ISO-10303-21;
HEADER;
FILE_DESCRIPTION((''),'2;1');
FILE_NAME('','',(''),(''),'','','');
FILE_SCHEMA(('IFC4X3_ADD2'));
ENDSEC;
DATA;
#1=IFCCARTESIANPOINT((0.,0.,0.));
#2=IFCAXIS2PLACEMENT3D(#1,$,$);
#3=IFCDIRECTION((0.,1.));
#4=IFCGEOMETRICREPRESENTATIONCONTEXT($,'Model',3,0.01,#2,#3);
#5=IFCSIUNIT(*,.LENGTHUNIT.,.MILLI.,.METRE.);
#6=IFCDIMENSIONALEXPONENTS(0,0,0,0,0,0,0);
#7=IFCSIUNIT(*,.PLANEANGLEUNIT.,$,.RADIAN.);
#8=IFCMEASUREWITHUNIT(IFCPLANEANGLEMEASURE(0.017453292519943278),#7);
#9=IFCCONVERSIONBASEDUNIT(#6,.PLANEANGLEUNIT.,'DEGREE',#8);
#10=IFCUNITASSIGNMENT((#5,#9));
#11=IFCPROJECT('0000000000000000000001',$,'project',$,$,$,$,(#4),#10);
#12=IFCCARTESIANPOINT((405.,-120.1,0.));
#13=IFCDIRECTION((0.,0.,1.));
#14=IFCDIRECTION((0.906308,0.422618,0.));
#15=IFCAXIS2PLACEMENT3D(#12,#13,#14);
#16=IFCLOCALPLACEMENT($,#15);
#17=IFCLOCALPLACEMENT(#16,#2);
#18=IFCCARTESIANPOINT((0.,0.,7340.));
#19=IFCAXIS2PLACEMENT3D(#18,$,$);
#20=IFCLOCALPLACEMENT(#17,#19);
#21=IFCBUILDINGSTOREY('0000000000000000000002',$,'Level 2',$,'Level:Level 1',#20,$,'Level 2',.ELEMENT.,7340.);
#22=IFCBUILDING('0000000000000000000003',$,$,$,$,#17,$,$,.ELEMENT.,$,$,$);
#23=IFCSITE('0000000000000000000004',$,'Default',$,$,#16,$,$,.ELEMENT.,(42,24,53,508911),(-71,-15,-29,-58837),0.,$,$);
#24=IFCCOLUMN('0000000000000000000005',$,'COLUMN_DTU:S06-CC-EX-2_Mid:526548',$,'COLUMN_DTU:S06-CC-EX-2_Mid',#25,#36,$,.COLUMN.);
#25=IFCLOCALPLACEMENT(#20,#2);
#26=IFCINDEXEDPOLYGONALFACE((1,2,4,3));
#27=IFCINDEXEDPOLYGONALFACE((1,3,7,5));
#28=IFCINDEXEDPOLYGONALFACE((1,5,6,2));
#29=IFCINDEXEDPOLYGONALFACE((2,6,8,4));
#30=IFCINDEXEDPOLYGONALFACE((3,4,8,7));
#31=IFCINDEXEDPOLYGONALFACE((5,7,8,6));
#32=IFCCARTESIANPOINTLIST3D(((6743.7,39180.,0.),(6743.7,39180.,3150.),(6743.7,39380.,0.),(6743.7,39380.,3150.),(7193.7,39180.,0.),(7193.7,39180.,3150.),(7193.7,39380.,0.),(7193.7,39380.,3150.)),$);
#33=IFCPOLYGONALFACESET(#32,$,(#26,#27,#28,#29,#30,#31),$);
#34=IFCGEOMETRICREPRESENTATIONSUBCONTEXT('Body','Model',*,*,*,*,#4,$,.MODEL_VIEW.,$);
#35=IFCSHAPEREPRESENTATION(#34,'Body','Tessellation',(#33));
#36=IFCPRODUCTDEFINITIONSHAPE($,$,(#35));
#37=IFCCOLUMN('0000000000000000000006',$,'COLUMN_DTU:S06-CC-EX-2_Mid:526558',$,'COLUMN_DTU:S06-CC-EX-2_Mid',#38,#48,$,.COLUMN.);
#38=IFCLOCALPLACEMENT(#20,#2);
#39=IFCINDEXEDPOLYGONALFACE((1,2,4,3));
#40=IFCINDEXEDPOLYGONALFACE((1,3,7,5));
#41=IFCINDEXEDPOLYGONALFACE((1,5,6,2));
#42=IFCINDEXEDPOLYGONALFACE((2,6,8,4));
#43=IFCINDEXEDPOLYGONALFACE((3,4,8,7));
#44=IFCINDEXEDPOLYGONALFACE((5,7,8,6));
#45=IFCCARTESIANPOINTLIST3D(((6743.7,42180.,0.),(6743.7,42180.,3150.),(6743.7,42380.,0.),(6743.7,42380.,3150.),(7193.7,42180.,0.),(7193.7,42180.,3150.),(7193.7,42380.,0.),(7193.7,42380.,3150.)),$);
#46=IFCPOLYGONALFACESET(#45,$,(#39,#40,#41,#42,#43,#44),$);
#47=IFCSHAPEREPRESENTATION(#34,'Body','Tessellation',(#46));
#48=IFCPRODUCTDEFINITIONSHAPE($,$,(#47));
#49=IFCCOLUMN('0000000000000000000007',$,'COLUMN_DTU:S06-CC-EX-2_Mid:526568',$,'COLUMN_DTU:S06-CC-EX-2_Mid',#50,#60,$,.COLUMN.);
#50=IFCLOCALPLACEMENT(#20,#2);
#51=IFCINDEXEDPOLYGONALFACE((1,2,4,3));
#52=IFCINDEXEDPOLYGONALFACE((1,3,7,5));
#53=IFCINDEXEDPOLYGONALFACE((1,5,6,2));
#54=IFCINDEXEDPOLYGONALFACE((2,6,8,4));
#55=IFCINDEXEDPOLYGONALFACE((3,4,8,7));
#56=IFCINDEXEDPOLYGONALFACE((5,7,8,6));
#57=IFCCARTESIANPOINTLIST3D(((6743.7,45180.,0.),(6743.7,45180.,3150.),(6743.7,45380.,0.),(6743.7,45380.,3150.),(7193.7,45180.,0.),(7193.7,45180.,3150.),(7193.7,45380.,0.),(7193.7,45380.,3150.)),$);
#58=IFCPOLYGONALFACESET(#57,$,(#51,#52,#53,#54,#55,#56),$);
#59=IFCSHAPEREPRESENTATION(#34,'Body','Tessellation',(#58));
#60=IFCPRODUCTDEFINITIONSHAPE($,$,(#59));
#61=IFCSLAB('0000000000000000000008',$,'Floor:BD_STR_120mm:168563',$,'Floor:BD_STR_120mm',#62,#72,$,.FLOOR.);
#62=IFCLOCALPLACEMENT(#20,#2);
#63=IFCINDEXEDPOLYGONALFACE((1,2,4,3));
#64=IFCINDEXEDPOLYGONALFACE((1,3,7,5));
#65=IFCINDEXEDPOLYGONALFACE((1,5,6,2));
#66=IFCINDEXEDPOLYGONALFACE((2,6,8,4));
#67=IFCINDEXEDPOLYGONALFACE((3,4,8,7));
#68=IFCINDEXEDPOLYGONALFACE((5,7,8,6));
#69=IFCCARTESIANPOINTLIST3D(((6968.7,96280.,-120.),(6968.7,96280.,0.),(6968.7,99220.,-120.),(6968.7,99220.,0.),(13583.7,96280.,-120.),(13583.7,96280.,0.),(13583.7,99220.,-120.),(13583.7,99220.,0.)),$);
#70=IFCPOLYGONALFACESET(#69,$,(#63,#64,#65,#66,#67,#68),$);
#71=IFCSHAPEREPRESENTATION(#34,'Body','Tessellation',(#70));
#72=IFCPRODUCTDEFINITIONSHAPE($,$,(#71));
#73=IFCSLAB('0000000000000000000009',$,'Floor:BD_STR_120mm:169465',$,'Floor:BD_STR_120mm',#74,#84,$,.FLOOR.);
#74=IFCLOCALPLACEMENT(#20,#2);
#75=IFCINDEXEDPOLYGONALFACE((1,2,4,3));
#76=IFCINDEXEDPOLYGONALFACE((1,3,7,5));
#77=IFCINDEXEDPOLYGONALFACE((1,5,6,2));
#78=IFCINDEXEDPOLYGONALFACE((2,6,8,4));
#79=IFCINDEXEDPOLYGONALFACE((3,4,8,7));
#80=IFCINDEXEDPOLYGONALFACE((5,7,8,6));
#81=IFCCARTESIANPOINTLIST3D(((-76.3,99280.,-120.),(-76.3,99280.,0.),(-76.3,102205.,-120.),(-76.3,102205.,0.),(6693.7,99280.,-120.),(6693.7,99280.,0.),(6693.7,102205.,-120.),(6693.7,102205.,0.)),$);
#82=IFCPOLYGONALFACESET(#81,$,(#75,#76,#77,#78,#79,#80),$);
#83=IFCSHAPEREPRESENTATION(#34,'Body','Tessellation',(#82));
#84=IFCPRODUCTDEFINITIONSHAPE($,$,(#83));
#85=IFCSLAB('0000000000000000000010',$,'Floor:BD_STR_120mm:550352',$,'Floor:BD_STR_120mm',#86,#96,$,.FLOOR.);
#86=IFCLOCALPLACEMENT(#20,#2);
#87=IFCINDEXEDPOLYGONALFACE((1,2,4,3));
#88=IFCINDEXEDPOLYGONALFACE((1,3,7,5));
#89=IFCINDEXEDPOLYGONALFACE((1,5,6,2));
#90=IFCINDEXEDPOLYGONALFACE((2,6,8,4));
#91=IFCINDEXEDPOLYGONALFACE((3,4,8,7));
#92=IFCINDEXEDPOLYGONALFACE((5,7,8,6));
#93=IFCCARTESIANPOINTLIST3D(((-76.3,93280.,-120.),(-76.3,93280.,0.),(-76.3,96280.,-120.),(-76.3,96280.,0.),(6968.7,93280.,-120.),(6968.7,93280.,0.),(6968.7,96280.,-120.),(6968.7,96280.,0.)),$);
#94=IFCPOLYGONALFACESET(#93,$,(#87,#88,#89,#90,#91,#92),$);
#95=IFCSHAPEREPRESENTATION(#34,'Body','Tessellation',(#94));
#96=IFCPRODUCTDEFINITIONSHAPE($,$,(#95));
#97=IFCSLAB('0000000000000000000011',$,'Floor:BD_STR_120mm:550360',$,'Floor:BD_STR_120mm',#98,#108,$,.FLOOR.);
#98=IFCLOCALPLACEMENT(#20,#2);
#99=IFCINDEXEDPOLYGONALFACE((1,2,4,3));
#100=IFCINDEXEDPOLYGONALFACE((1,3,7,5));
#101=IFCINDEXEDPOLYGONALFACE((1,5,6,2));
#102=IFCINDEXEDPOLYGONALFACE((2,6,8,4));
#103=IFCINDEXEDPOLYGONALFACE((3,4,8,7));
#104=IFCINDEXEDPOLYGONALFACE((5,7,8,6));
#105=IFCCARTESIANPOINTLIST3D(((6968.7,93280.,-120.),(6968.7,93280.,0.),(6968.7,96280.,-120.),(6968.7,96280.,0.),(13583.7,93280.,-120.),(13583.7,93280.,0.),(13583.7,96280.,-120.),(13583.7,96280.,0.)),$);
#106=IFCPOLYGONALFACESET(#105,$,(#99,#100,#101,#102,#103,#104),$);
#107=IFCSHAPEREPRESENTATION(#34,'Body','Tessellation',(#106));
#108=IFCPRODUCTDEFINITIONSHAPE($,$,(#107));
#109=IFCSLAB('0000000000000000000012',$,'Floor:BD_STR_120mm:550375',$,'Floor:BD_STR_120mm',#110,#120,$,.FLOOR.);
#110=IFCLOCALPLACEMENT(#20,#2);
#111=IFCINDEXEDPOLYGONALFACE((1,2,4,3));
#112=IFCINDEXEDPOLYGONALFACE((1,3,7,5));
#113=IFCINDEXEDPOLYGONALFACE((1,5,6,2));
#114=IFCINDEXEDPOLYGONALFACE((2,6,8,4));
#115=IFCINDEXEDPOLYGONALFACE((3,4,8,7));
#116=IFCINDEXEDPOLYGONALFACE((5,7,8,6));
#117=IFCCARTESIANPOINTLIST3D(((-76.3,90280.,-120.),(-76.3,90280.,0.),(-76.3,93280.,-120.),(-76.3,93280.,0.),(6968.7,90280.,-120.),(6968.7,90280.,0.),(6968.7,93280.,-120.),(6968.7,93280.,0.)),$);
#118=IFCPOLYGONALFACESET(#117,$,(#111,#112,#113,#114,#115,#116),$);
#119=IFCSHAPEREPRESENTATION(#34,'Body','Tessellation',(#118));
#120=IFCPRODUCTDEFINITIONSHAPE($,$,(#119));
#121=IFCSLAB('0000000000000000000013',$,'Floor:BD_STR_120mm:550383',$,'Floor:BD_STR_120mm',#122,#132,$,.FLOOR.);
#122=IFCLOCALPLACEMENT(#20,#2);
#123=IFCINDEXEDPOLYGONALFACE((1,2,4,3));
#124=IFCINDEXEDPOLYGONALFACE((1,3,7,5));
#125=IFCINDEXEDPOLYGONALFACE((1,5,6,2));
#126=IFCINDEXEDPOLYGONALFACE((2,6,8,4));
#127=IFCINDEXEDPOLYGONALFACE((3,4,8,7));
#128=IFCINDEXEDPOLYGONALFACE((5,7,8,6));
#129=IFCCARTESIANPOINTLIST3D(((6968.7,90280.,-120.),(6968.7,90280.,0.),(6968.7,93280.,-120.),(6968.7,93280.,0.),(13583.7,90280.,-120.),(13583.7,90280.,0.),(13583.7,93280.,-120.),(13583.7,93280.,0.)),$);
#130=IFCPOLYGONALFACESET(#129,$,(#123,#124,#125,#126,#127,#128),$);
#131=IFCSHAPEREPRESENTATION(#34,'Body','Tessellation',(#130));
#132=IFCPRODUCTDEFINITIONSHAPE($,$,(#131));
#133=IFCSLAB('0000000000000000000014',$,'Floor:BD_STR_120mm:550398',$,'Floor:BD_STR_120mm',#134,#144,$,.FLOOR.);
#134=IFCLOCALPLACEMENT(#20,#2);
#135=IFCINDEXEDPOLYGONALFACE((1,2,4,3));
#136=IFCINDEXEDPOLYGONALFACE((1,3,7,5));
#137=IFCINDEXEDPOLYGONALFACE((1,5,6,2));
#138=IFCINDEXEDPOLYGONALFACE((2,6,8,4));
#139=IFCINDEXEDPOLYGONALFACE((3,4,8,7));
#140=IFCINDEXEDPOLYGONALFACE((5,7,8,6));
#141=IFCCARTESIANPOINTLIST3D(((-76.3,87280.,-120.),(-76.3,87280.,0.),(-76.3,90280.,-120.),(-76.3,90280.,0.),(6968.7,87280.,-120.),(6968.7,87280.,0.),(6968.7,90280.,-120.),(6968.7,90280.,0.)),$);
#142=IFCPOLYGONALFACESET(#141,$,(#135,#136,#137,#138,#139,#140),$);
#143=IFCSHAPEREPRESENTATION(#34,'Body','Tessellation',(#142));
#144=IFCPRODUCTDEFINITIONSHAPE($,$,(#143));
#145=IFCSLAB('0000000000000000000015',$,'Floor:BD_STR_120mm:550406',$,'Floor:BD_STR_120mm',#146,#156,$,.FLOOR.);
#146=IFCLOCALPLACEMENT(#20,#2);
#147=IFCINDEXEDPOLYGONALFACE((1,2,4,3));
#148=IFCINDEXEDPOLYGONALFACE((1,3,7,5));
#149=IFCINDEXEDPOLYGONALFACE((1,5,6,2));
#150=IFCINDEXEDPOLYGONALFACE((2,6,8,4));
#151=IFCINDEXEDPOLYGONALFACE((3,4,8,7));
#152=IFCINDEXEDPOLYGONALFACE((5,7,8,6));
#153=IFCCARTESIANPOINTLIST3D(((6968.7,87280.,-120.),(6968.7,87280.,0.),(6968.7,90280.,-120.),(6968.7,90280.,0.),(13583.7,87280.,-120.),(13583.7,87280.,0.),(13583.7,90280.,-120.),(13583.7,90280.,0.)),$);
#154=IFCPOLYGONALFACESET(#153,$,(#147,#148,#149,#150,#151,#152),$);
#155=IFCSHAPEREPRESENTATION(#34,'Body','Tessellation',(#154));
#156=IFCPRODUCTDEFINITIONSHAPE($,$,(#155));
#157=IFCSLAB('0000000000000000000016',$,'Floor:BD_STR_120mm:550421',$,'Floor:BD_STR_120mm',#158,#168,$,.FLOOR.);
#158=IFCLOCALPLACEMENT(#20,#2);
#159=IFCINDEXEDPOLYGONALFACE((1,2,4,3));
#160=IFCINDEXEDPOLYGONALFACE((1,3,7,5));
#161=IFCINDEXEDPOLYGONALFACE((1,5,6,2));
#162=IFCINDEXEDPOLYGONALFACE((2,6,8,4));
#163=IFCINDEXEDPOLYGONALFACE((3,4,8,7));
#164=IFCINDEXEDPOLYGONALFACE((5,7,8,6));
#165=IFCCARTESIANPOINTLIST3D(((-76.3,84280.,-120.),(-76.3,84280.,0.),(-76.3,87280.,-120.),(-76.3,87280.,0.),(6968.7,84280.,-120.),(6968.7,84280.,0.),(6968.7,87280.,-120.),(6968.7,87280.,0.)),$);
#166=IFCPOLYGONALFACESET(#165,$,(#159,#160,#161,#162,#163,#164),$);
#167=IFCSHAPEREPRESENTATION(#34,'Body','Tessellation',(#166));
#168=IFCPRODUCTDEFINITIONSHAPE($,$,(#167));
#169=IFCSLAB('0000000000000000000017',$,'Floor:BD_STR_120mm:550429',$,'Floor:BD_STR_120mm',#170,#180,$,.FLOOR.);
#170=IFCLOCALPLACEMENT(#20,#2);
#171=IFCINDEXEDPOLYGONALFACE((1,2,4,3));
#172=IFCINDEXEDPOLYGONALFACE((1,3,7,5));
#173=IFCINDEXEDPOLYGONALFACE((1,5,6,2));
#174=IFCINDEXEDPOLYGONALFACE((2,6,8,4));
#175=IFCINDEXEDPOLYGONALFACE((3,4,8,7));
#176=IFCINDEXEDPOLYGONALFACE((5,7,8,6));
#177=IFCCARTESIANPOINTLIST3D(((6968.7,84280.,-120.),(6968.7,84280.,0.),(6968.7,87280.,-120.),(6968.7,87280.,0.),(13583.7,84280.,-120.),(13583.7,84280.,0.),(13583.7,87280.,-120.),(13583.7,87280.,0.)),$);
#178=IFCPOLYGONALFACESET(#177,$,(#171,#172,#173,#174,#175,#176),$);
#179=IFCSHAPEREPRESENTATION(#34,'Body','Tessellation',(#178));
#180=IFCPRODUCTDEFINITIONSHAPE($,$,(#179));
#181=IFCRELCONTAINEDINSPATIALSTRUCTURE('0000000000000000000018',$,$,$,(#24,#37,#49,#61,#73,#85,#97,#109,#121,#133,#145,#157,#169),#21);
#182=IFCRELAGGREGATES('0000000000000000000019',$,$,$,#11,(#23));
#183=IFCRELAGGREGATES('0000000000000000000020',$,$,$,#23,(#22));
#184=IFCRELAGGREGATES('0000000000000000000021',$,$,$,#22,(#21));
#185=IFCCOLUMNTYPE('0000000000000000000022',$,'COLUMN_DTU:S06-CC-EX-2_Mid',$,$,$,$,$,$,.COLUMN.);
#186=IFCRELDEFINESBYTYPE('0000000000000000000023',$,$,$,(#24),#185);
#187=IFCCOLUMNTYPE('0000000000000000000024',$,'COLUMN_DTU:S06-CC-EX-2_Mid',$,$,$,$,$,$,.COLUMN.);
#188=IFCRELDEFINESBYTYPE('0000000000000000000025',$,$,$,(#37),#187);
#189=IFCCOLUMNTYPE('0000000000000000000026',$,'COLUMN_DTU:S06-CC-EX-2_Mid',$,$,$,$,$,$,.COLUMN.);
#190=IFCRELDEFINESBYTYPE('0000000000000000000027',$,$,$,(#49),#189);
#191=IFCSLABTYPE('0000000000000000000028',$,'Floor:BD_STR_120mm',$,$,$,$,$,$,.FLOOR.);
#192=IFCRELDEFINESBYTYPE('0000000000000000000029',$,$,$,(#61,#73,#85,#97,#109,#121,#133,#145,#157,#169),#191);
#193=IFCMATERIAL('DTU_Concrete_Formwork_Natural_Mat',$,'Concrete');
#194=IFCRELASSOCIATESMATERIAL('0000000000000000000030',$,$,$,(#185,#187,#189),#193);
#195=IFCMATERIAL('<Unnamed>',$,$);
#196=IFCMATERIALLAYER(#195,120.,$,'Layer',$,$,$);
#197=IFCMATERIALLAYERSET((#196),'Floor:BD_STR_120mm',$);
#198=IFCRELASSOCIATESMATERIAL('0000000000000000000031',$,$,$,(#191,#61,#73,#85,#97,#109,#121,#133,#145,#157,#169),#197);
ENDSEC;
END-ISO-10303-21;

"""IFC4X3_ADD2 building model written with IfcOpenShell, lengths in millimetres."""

from ifc_helpers import new_model, entity, si_unit, converted_unit, direction, frame, frame_2d, origin, origin_2d_with_axis, place, context, subcontext, project, spatial, rectangle, extrude, source, transform, mapped, material, layer, layer_set, layer_usage, material_profile, profile_set, type_object, type_shapes, element, save


model = new_model("IFC4X3_ADD2")

# Units and contexts
model_context = context("Model", 3, precision=0.01, world=origin(), true_north=direction((0.0, 1.0)))
body_context = subcontext(model_context, "Body", "Model", "MODEL_VIEW")
ifc_project = project(units=[si_unit("LENGTHUNIT", "METRE", prefix="MILLI"), converted_unit("PLANEANGLEUNIT", "DEGREE", entity("IfcPlaneAngleMeasure", 0.017453292519943278), si_unit("PLANEANGLEUNIT", "RADIAN"), dimensions=[0, 0, 0, 0, 0, 0, 0])], contexts=[model_context])

# Site, building, storey
site_placement = place(None, frame((405.0, -120.1, 0.0), z_axis=(0.0, 0.0, 1.0), x_axis=(0.906308, 0.422618, 0.0)))
site = spatial("IfcSite", under=ifc_project, at=site_placement, Name="Default", CompositionType="ELEMENT", RefLatitude=(42, 24, 53, 508911), RefLongitude=(-71, -15, -29, -58837), RefElevation=0.0)
building_placement = place(site_placement, origin())
building = spatial("IfcBuilding", under=site, at=building_placement, CompositionType="ELEMENT")
storey_placement = place(building_placement, frame((0.0, 0.0, 7340.0)))
storey = spatial("IfcBuildingStorey", under=building, at=storey_placement, Name="Level 2", ObjectType="Level:Level 1", LongName="Level 2", CompositionType="ELEMENT", Elevation=7340.0)

# Columns
ifc_material_1 = material(Name="DTU_Concrete_Formwork_Natural_Mat", Category="Concrete")
ifc_material_profile_1 = material_profile(ifc_material_1, rectangle(XDim=200.0, YDim=450.0, at=origin_2d_with_axis()), Name="S06-CC-EX-2_Mid")
ifc_profile_set_1 = profile_set([ifc_material_profile_1], Name="S06-CC-EX-2_Mid")
column_type_1 = type_object("IfcColumnType", Name="COLUMN_DTU:S06-CC-EX-2_Mid", PredefinedType="COLUMN", material=ifc_profile_set_1)
shared_shape_1 = source(origin(), body_context, "Body", "SweptSolid", [
    extrude(rectangle(XDim=200.0, YDim=450.0, at=frame_2d((0.0, 0.0), x_axis=(1.0, 0.0))), frame((6968.7, 39280.0, 7340.0), z_axis=(0.0, 0.0, 1.0), x_axis=(0.0, 1.0, 0.0)), (0.0, 0.0, 1.0), 3150.0),
])
type_shapes(column_type_1, [shared_shape_1])
column_1_placement = place(storey_placement, frame((0.0, 0.0, -7340.0)))
element("IfcColumn", 1, at=column_1_placement, inside=storey, type_object=column_type_1, Name="COLUMN_DTU:S06-CC-EX-2_Mid:526548", ObjectType="COLUMN_DTU:S06-CC-EX-2_Mid", PredefinedType="COLUMN", context=body_context, shape_type="MappedRepresentation", body=[
    mapped(shared_shape_1, transform((0.0, 0.0, 0.0), scale=1.0)),
])
column_type_2 = type_object("IfcColumnType", Name="COLUMN_DTU:S06-CC-EX-2_Mid", PredefinedType="COLUMN", material=ifc_profile_set_1)
shared_shape_2 = source(origin(), body_context, "Body", "SweptSolid", [
    extrude(rectangle(XDim=200.0, YDim=450.0, at=frame_2d((0.0, 0.0), x_axis=(1.0, 0.0))), frame((6968.7, 42280.0, 7340.0), z_axis=(0.0, 0.0, 1.0), x_axis=(0.0, 1.0, 0.0)), (0.0, 0.0, 1.0), 3150.0),
])
type_shapes(column_type_2, [shared_shape_2])
column_2_placement = place(storey_placement, frame((0.0, 0.0, -7340.0)))
element("IfcColumn", 2, at=column_2_placement, inside=storey, type_object=column_type_2, Name="COLUMN_DTU:S06-CC-EX-2_Mid:526558", ObjectType="COLUMN_DTU:S06-CC-EX-2_Mid", PredefinedType="COLUMN", context=body_context, shape_type="MappedRepresentation", body=[
    mapped(shared_shape_2, transform((0.0, 0.0, 0.0), scale=1.0)),
])
column_type_3 = type_object("IfcColumnType", Name="COLUMN_DTU:S06-CC-EX-2_Mid", PredefinedType="COLUMN", material=ifc_profile_set_1)
shared_shape_3 = source(origin(), body_context, "Body", "SweptSolid", [
    extrude(rectangle(XDim=200.0, YDim=450.0, at=frame_2d((0.0, 0.0), x_axis=(1.0, 0.0))), frame((6968.7, 45280.0, 7340.0), z_axis=(0.0, 0.0, 1.0), x_axis=(0.0, 1.0, 0.0)), (0.0, 0.0, 1.0), 3150.0),
])
type_shapes(column_type_3, [shared_shape_3])
column_3_placement = place(storey_placement, frame((0.0, 0.0, -7340.0)))
element("IfcColumn", 3, at=column_3_placement, inside=storey, type_object=column_type_3, Name="COLUMN_DTU:S06-CC-EX-2_Mid:526568", ObjectType="COLUMN_DTU:S06-CC-EX-2_Mid", PredefinedType="COLUMN", context=body_context, shape_type="MappedRepresentation", body=[
    mapped(shared_shape_3, transform((0.0, 0.0, 0.0), scale=1.0)),
])

# Slabs
ifc_material_2 = material(Name="<Unnamed>")
ifc_layer_1 = layer(ifc_material_2, 120.0, Name="Layer")
ifc_layer_set_1 = layer_set([ifc_layer_1], Name="Floor:BD_STR_120mm")
slab_type_1 = type_object("IfcSlabType", Name="Floor:BD_STR_120mm", PredefinedType="FLOOR", material=ifc_layer_set_1)
ifc_layer_usage_1 = layer_usage(ifc_layer_set_1, "AXIS3", "POSITIVE", 0.0)
slab_1_placement = place(storey_placement, origin())
element("IfcSlab", 4, at=slab_1_placement, inside=storey, type_object=slab_type_1, material=ifc_layer_usage_1, Name="Floor:BD_STR_120mm:168563", ObjectType="Floor:BD_STR_120mm", PredefinedType="FLOOR", context=body_context, shape_type="SweptSolid", body=[
    extrude(rectangle(XDim=2940.0, YDim=6615.0, at=frame_2d((0.0, 0.0), x_axis=(1.0, 0.0))), frame((10276.2, 97750.0, 0.0), z_axis=(0.0, 0.0, -1.0), x_axis=(0.0, 1.0, 0.0)), (0.0, 0.0, 1.0), 120.0),
])
ifc_layer_usage_2 = layer_usage(ifc_layer_set_1, "AXIS3", "POSITIVE", 0.0)
slab_2_placement = place(storey_placement, origin())
element("IfcSlab", 5, at=slab_2_placement, inside=storey, type_object=slab_type_1, material=ifc_layer_usage_2, Name="Floor:BD_STR_120mm:169465", ObjectType="Floor:BD_STR_120mm", PredefinedType="FLOOR", context=body_context, shape_type="SweptSolid", body=[
    extrude(rectangle(XDim=2925.0, YDim=6770.0, at=origin_2d_with_axis()), frame((3308.7, 100742.5, 0.0), z_axis=(0.0, 0.0, -1.0), x_axis=(0.0, 1.0, 0.0)), (0.0, 0.0, 1.0), 120.0),
])
ifc_layer_usage_3 = layer_usage(ifc_layer_set_1, "AXIS3", "POSITIVE", 0.0)
slab_3_placement = place(storey_placement, origin())
element("IfcSlab", 6, at=slab_3_placement, inside=storey, type_object=slab_type_1, material=ifc_layer_usage_3, Name="Floor:BD_STR_120mm:550352", ObjectType="Floor:BD_STR_120mm", PredefinedType="FLOOR", context=body_context, shape_type="SweptSolid", body=[
    extrude(rectangle(XDim=3000.0, YDim=7045.0, at=origin_2d_with_axis()), frame((3446.2, 94780.0, 0.0), z_axis=(0.0, 0.0, -1.0), x_axis=(0.0, 1.0, 0.0)), (0.0, 0.0, 1.0), 120.0),
])
ifc_layer_usage_4 = layer_usage(ifc_layer_set_1, "AXIS3", "POSITIVE", 0.0)
slab_4_placement = place(storey_placement, origin())
element("IfcSlab", 7, at=slab_4_placement, inside=storey, type_object=slab_type_1, material=ifc_layer_usage_4, Name="Floor:BD_STR_120mm:550360", ObjectType="Floor:BD_STR_120mm", PredefinedType="FLOOR", context=body_context, shape_type="SweptSolid", body=[
    extrude(rectangle(XDim=3000.0, YDim=6615.0, at=frame_2d((0.0, 0.0), x_axis=(1.0, 0.0))), frame((10276.2, 94780.0, 0.0), z_axis=(0.0, 0.0, -1.0), x_axis=(0.0, 1.0, 0.0)), (0.0, 0.0, 1.0), 120.0),
])
ifc_layer_usage_5 = layer_usage(ifc_layer_set_1, "AXIS3", "POSITIVE", 0.0)
slab_5_placement = place(storey_placement, origin())
element("IfcSlab", 8, at=slab_5_placement, inside=storey, type_object=slab_type_1, material=ifc_layer_usage_5, Name="Floor:BD_STR_120mm:550375", ObjectType="Floor:BD_STR_120mm", PredefinedType="FLOOR", context=body_context, shape_type="SweptSolid", body=[
    extrude(rectangle(XDim=3000.0, YDim=7045.0, at=origin_2d_with_axis()), frame((3446.2, 91780.0, 0.0), z_axis=(0.0, 0.0, -1.0), x_axis=(0.0, 1.0, 0.0)), (0.0, 0.0, 1.0), 120.0),
])
ifc_layer_usage_6 = layer_usage(ifc_layer_set_1, "AXIS3", "POSITIVE", 0.0)
slab_6_placement = place(storey_placement, origin())
element("IfcSlab", 9, at=slab_6_placement, inside=storey, type_object=slab_type_1, material=ifc_layer_usage_6, Name="Floor:BD_STR_120mm:550383", ObjectType="Floor:BD_STR_120mm", PredefinedType="FLOOR", context=body_context, shape_type="SweptSolid", body=[
    extrude(rectangle(XDim=3000.0, YDim=6615.0, at=frame_2d((0.0, 0.0), x_axis=(1.0, 0.0))), frame((10276.2, 91780.0, 0.0), z_axis=(0.0, 0.0, -1.0), x_axis=(0.0, 1.0, 0.0)), (0.0, 0.0, 1.0), 120.0),
])
ifc_layer_usage_7 = layer_usage(ifc_layer_set_1, "AXIS3", "POSITIVE", 0.0)
slab_7_placement = place(storey_placement, origin())
element("IfcSlab", 10, at=slab_7_placement, inside=storey, type_object=slab_type_1, material=ifc_layer_usage_7, Name="Floor:BD_STR_120mm:550398", ObjectType="Floor:BD_STR_120mm", PredefinedType="FLOOR", context=body_context, shape_type="SweptSolid", body=[
    extrude(rectangle(XDim=3000.0, YDim=7045.0, at=origin_2d_with_axis()), frame((3446.2, 88780.0, 0.0), z_axis=(0.0, 0.0, -1.0), x_axis=(0.0, 1.0, 0.0)), (0.0, 0.0, 1.0), 120.0),
])
ifc_layer_usage_8 = layer_usage(ifc_layer_set_1, "AXIS3", "POSITIVE", 0.0)
slab_8_placement = place(storey_placement, origin())
element("IfcSlab", 11, at=slab_8_placement, inside=storey, type_object=slab_type_1, material=ifc_layer_usage_8, Name="Floor:BD_STR_120mm:550406", ObjectType="Floor:BD_STR_120mm", PredefinedType="FLOOR", context=body_context, shape_type="SweptSolid", body=[
    extrude(rectangle(XDim=3000.0, YDim=6615.0, at=frame_2d((0.0, 0.0), x_axis=(1.0, 0.0))), frame((10276.2, 88780.0, 0.0), z_axis=(0.0, 0.0, -1.0), x_axis=(0.0, 1.0, 0.0)), (0.0, 0.0, 1.0), 120.0),
])
ifc_layer_usage_9 = layer_usage(ifc_layer_set_1, "AXIS3", "POSITIVE", 0.0)
slab_9_placement = place(storey_placement, origin())
element("IfcSlab", 12, at=slab_9_placement, inside=storey, type_object=slab_type_1, material=ifc_layer_usage_9, Name="Floor:BD_STR_120mm:550421", ObjectType="Floor:BD_STR_120mm", PredefinedType="FLOOR", context=body_context, shape_type="SweptSolid", body=[
    extrude(rectangle(XDim=3000.0, YDim=7045.0, at=origin_2d_with_axis()), frame((3446.2, 85780.0, 0.0), z_axis=(0.0, 0.0, -1.0), x_axis=(0.0, 1.0, 0.0)), (0.0, 0.0, 1.0), 120.0),
])
ifc_layer_usage_10 = layer_usage(ifc_layer_set_1, "AXIS3", "POSITIVE", 0.0)
slab_10_placement = place(storey_placement, origin())
element("IfcSlab", 13, at=slab_10_placement, inside=storey, type_object=slab_type_1, material=ifc_layer_usage_10, Name="Floor:BD_STR_120mm:550429", ObjectType="Floor:BD_STR_120mm", PredefinedType="FLOOR", context=body_context, shape_type="SweptSolid", body=[
    extrude(rectangle(XDim=3000.0, YDim=6615.0, at=frame_2d((0.0, 0.0), x_axis=(1.0, 0.0))), frame((10276.2, 85780.0, 0.0), z_axis=(0.0, 0.0, -1.0), x_axis=(0.0, 1.0, 0.0)), (0.0, 0.0, 1.0), 120.0),
])

save(model, "model.ifc")
